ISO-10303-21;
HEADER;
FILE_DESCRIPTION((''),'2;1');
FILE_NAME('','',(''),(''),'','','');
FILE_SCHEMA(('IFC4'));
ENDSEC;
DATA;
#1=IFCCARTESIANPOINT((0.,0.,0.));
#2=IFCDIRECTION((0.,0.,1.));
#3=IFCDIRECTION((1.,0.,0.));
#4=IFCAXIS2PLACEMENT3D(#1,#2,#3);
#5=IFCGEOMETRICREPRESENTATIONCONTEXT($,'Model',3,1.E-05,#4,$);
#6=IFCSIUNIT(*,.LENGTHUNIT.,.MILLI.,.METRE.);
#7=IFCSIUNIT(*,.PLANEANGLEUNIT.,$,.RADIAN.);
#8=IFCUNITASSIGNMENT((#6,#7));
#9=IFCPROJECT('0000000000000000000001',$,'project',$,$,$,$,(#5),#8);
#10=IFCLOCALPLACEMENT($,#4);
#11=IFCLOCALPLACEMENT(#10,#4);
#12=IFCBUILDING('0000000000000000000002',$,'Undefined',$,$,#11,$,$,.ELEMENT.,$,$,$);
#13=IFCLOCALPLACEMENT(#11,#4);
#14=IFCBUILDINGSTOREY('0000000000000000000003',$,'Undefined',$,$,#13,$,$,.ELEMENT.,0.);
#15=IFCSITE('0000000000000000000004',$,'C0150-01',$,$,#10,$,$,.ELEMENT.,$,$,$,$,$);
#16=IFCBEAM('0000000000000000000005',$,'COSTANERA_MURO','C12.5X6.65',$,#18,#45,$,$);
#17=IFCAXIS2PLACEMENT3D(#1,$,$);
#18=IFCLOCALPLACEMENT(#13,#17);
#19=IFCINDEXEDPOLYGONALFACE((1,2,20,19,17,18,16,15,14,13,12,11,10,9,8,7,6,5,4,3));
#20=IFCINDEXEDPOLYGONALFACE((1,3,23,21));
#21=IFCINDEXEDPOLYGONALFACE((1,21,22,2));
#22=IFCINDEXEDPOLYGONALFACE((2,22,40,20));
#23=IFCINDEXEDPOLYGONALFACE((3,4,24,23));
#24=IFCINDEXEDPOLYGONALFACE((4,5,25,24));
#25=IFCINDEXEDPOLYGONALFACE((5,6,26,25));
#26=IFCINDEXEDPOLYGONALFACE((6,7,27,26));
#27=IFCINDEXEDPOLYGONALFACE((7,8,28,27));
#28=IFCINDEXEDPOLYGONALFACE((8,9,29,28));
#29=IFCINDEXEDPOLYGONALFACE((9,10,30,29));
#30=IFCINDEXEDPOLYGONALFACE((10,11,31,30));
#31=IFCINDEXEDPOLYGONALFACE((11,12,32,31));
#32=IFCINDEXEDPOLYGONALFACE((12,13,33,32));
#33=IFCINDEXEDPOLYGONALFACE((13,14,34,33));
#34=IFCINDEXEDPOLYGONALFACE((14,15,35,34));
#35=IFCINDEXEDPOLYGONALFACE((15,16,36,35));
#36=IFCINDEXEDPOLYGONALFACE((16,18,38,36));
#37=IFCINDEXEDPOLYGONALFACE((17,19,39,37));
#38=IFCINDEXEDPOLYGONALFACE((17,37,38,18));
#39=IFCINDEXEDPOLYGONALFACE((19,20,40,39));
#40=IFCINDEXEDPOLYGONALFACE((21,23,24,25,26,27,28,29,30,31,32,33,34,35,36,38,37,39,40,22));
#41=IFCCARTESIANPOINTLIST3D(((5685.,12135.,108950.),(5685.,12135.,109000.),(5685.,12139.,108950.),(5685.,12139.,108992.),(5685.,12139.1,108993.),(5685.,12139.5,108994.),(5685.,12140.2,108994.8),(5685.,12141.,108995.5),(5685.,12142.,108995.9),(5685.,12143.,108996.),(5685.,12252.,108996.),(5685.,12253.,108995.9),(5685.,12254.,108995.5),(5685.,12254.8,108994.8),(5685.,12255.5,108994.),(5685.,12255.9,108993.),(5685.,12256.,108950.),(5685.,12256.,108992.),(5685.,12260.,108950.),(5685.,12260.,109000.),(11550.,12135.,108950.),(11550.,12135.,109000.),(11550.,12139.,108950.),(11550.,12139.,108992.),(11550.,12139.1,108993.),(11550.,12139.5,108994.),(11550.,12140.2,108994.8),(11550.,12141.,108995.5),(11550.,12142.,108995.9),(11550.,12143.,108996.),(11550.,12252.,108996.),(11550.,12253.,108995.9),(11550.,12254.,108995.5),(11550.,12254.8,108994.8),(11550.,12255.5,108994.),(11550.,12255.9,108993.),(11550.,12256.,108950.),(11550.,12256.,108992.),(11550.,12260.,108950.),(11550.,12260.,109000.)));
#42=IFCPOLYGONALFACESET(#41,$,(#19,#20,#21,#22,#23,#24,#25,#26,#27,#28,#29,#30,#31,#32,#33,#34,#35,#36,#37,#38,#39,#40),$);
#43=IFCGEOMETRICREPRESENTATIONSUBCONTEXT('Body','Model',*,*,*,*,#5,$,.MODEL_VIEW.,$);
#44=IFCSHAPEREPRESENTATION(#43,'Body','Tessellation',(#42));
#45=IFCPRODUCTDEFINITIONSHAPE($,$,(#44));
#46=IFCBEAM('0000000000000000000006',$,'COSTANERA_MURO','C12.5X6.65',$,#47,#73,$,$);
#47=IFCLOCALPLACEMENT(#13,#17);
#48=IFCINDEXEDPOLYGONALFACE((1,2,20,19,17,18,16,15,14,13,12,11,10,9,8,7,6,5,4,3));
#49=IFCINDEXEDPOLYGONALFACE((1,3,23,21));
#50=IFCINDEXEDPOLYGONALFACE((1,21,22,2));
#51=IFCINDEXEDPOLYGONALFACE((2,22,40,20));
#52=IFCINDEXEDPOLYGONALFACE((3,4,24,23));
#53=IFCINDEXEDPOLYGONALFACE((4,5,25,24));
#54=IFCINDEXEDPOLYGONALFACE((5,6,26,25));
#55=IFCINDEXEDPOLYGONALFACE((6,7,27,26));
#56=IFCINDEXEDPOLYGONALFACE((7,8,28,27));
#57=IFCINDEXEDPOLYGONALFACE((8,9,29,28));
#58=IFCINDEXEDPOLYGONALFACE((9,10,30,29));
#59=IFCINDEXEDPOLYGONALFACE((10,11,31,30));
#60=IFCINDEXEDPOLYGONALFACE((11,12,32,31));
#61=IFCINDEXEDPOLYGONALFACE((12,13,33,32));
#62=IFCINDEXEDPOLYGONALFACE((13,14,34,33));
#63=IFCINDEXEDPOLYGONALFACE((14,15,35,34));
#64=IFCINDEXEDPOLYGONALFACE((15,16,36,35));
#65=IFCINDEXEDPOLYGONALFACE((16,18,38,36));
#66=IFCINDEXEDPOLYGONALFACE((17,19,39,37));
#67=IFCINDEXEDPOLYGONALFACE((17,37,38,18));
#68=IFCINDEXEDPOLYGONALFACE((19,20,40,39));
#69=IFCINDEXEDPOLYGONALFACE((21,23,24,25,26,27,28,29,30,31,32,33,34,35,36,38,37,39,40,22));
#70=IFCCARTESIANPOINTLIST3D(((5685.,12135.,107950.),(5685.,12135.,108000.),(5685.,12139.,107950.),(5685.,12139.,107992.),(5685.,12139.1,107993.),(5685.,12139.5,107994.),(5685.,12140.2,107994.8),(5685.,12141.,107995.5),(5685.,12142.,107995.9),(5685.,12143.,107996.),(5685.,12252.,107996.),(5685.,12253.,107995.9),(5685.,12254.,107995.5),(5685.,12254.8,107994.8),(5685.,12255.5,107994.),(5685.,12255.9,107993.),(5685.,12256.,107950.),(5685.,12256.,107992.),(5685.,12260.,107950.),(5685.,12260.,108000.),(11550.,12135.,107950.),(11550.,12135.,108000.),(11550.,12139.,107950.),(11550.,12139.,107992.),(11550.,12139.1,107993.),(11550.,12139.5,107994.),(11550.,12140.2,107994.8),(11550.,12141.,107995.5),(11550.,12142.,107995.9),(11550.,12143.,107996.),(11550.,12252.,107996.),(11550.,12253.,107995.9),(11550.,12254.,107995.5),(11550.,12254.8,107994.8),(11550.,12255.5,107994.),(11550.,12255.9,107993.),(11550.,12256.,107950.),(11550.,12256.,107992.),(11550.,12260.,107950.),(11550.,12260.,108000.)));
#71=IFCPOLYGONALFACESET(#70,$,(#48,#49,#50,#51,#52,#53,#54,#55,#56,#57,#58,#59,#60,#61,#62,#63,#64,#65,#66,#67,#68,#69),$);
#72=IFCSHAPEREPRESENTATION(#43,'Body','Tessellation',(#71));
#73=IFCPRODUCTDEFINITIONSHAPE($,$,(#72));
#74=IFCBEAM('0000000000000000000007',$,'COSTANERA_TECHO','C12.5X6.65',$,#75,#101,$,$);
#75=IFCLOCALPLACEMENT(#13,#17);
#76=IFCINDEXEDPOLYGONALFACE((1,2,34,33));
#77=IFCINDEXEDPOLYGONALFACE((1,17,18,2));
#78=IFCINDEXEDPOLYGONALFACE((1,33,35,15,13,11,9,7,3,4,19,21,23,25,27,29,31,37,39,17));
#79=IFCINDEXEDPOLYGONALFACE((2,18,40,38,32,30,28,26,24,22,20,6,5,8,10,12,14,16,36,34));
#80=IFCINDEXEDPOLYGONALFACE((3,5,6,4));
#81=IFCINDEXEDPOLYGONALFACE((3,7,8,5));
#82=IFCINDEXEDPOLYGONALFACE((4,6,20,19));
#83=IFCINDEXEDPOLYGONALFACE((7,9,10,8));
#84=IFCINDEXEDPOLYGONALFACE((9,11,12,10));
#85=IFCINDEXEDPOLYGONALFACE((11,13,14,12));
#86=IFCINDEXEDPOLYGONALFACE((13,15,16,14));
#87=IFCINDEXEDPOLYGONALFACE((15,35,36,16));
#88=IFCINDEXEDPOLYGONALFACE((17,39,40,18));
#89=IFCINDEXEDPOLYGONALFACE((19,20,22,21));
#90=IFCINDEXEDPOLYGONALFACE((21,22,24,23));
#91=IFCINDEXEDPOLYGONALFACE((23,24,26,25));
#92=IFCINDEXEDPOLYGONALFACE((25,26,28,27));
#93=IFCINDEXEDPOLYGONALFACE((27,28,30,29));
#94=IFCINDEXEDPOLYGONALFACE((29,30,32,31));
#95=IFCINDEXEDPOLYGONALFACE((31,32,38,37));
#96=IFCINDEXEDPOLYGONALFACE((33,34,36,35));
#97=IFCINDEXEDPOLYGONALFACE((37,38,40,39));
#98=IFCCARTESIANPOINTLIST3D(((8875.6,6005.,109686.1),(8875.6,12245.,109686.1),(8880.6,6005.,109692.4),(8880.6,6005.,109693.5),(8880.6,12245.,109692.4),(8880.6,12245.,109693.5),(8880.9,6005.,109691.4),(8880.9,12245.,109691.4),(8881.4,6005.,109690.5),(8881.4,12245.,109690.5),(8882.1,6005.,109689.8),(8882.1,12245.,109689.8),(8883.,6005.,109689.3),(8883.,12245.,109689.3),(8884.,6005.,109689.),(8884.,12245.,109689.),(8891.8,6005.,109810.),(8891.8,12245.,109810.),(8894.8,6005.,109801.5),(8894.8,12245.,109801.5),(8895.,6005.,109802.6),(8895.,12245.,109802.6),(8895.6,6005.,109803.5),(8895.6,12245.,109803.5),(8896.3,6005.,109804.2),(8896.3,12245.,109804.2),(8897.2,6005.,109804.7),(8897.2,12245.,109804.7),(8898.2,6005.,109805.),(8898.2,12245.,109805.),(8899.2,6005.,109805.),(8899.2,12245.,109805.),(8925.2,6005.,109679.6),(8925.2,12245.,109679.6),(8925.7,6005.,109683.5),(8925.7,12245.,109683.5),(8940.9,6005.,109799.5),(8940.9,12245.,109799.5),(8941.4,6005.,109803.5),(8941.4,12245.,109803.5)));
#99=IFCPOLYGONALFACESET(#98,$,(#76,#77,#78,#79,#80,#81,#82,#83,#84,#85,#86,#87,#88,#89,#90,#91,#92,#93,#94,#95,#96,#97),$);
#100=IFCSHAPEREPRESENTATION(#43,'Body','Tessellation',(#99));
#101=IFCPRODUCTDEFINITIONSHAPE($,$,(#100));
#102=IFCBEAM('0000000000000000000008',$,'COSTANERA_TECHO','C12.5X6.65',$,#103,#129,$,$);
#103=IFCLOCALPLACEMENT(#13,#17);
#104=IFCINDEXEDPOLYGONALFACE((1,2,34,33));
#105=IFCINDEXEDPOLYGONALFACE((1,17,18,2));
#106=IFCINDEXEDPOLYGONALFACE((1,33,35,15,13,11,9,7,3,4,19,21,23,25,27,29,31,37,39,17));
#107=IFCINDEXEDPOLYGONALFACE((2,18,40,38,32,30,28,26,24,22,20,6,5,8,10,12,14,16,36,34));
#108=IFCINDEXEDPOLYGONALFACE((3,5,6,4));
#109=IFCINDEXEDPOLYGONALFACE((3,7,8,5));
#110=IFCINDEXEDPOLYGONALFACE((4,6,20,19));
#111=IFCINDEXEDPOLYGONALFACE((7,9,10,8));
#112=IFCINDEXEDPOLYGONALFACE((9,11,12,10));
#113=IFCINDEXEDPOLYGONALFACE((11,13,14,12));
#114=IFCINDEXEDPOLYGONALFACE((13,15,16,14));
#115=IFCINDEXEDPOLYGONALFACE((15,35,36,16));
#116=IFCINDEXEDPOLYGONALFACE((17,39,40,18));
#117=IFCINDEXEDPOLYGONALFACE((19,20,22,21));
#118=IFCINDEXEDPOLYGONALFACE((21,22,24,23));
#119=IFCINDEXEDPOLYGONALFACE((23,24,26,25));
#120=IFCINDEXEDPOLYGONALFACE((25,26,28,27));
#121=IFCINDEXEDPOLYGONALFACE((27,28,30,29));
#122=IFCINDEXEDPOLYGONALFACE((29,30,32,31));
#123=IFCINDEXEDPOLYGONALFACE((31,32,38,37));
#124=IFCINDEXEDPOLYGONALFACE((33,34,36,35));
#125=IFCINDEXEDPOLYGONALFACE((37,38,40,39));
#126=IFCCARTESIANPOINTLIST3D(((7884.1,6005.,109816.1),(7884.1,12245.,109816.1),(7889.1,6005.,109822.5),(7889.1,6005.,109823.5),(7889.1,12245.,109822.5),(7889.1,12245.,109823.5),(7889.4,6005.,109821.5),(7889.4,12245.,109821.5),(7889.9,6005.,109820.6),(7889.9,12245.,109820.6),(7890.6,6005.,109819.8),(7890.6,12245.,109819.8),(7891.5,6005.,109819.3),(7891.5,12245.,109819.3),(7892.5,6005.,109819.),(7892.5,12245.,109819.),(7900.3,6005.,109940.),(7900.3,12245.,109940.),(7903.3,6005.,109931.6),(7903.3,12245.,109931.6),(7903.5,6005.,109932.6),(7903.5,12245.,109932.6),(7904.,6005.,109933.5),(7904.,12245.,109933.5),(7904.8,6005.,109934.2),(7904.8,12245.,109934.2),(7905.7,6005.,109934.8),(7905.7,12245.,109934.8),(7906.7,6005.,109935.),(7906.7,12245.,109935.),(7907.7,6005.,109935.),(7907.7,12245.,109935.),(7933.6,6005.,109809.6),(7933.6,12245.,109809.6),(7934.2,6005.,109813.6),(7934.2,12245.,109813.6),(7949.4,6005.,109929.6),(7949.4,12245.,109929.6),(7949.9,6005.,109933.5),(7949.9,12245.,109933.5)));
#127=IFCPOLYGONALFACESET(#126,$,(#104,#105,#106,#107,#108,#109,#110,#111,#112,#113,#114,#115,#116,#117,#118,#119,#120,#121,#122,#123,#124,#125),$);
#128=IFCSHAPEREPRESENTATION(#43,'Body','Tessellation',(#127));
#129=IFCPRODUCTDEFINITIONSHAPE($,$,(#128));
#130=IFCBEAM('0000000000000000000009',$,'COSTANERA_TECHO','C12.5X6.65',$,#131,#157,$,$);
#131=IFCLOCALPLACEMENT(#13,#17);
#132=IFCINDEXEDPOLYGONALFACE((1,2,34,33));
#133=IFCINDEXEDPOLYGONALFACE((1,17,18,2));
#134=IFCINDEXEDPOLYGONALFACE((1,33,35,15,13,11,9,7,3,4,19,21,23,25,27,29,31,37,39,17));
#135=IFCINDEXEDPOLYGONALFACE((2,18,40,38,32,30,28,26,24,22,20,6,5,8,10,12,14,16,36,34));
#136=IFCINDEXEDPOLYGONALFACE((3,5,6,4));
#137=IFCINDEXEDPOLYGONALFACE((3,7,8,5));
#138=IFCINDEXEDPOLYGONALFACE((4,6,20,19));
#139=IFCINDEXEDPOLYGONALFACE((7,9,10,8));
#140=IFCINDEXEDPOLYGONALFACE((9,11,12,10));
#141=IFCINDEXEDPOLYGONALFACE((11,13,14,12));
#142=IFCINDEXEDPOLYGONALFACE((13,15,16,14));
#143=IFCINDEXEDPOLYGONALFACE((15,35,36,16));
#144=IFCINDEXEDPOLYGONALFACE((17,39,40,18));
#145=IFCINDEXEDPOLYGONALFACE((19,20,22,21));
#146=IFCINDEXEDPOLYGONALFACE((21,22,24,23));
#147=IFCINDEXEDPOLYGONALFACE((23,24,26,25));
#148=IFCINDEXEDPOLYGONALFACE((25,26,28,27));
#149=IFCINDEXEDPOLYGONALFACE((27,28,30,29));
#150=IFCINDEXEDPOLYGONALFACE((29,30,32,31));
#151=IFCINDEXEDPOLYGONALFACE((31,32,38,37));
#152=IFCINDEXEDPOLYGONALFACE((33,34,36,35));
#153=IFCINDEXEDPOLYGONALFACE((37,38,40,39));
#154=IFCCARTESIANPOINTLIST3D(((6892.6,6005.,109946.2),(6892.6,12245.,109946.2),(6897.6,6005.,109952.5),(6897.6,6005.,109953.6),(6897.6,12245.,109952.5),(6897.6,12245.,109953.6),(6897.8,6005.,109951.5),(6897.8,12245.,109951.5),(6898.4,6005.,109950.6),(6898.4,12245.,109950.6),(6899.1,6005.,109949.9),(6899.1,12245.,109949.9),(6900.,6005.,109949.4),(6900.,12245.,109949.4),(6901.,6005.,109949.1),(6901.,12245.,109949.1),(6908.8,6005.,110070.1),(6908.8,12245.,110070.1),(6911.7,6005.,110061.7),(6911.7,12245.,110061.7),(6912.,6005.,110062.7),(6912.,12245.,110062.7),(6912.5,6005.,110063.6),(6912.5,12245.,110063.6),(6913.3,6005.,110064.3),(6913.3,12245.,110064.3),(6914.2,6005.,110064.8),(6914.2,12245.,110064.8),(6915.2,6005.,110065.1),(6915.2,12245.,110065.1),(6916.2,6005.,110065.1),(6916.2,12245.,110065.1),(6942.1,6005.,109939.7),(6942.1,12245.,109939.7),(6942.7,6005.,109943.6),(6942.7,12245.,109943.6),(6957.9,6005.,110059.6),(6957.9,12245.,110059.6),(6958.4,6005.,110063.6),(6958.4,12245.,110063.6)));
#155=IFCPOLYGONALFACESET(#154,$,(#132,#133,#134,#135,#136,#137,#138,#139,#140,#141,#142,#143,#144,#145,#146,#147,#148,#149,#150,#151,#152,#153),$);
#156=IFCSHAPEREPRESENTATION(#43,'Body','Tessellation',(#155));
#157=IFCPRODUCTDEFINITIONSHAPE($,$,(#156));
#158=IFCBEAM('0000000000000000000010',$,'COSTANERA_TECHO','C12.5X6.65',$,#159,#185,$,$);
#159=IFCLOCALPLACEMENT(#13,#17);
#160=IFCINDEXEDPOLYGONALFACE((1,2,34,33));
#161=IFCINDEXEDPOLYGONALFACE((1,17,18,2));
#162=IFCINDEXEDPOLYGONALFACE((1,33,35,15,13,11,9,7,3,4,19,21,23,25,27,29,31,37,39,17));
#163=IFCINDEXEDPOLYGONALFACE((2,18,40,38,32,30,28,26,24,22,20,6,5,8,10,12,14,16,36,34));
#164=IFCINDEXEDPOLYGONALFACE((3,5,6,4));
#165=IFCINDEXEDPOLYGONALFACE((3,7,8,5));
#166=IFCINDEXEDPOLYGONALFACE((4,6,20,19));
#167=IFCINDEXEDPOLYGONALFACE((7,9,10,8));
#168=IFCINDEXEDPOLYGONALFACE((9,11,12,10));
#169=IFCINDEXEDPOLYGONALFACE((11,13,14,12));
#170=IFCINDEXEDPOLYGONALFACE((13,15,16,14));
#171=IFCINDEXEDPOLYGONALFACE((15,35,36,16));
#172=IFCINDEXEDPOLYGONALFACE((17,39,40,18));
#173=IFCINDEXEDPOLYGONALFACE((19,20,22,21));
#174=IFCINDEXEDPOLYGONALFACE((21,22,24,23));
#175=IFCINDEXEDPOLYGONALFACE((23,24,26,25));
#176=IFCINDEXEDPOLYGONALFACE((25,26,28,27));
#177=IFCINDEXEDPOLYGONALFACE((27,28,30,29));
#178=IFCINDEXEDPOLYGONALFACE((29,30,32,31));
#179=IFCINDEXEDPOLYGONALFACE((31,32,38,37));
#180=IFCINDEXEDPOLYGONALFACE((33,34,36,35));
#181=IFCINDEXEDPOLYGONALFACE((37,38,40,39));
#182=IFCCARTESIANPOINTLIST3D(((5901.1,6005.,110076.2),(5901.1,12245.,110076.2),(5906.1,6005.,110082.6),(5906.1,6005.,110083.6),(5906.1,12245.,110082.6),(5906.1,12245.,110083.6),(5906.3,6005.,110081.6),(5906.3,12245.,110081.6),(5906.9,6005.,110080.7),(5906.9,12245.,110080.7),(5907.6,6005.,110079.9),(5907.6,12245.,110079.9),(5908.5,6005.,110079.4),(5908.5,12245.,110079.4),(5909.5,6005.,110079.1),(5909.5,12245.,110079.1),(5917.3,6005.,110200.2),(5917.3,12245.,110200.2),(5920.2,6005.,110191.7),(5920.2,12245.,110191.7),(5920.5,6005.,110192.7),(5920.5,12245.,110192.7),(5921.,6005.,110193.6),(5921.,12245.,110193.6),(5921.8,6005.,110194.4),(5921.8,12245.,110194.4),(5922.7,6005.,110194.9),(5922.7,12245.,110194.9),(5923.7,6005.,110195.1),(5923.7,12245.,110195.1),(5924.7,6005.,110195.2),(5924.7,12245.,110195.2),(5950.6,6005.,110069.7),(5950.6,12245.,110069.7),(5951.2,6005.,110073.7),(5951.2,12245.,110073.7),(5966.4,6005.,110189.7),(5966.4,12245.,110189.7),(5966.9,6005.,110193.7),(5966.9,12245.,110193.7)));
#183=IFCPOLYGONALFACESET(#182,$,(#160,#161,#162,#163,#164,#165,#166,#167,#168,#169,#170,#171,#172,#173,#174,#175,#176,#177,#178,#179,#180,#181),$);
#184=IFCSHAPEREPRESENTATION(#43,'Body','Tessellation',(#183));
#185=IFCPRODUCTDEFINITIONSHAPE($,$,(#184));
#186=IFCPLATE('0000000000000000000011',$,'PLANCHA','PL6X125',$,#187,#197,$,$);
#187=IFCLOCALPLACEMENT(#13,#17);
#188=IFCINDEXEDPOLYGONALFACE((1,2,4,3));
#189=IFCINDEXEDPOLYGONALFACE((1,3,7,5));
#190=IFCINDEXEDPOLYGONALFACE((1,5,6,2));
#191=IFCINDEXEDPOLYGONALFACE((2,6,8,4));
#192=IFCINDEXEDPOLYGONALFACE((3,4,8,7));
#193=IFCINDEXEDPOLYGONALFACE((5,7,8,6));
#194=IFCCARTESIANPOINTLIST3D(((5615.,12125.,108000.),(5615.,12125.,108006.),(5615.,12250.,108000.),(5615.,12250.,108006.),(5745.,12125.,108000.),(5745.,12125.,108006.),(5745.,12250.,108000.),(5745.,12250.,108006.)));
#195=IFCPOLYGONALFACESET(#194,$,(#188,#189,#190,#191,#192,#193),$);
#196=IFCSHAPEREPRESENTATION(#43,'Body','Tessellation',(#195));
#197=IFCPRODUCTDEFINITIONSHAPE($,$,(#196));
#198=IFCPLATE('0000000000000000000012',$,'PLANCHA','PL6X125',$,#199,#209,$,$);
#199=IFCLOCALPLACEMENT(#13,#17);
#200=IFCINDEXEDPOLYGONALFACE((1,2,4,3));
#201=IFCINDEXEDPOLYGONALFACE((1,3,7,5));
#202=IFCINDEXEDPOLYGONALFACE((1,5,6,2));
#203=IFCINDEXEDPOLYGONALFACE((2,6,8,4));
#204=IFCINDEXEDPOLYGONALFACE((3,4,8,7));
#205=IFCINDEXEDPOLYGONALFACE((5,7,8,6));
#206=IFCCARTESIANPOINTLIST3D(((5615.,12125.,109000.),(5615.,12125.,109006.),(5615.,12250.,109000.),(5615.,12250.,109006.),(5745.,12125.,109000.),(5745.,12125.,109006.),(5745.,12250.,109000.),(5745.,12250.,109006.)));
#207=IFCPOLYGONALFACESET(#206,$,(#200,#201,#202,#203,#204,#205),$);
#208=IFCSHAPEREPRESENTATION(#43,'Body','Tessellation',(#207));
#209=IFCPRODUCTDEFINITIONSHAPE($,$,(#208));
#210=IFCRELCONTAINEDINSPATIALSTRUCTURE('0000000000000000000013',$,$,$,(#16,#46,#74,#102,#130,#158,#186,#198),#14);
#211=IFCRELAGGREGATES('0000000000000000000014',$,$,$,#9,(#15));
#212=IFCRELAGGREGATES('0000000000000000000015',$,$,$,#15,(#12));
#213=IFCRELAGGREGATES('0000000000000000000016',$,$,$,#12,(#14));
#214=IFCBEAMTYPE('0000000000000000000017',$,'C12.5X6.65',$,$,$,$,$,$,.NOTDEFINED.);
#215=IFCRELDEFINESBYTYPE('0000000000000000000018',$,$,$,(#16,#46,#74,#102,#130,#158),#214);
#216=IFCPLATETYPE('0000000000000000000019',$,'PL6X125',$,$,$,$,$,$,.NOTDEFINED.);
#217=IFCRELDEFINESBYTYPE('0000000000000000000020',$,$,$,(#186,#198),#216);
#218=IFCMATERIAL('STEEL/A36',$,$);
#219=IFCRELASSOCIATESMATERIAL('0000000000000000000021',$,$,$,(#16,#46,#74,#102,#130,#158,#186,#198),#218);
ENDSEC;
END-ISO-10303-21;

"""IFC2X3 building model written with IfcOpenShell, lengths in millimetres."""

from ifc_helpers import new_model, si_unit, frame, origin_with_axes, origin_2d_with_axis, place, context, subcontext, project, spatial, polyline, u_section, outline, extrude, material, type_object, element, save


model = new_model("IFC2X3")

# Units and contexts
model_context = context("Model", 3, precision=1e-05, world=origin_with_axes())
body_context = subcontext(model_context, "Body", "Model", "MODEL_VIEW")
ifc_project = project(units=[si_unit("LENGTHUNIT", "METRE", prefix="MILLI"), si_unit("PLANEANGLEUNIT", "RADIAN")], contexts=[model_context])

# Site, building, storey
site_placement = place(None, origin_with_axes())
site = spatial("IfcSite", under=ifc_project, at=site_placement, Name="C0150-01", CompositionType="ELEMENT")
building_placement = place(site_placement, origin_with_axes())
building = spatial("IfcBuilding", under=site, at=building_placement, Name="Undefined", CompositionType="ELEMENT")
storey_placement = place(building_placement, origin_with_axes())
storey = spatial("IfcBuildingStorey", under=building, at=storey_placement, Name="Undefined", CompositionType="ELEMENT", Elevation=0.0)

# Beams
ifc_material_1 = material(Name="STEEL/A36")
beam_type = type_object("IfcBeamType", Name="C12.5X6.65", PredefinedType="NOTDEFINED")
for number, where, z_axis, x_axis, name in (
    (1, (5685.0, 12197.5, 108975.0), (0.0, -1.0, 0.0), (1.0, 0.0, 0.0), "COSTANERA_MURO"),
    (2, (5685.0, 12197.5, 107975.0), (0.0, -1.0, 0.0), (1.0, 0.0, 0.0), "COSTANERA_MURO"),
):
    element("IfcBeam", number, at=place(storey_placement, frame(where, z_axis=z_axis, x_axis=x_axis)), inside=storey, type_object=beam_type, material=ifc_material_1, Name=name, Description="C12.5X6.65", context=body_context, shape_type="SweptSolid", body=[
        extrude(u_section(Depth=125.0, FlangeWidth=50.0, WebThickness=4.0, FlangeThickness=4.0, FilletRadius=4.0, at=origin_2d_with_axis()), frame((5865.0, 0.0, 0.0), z_axis=(-1.0, 0.0, 0.0), x_axis=(0.0, -1.0, 0.0)), (0.0, 0.0, 1.0), 5865.0),
    ])
for number, where, z_axis, x_axis, name in (
    (3, (8908.5, 12245.0, 109744.8), (-0.130054, 0.0, -0.991507), (0.0, -1.0, 0.0), "COSTANERA_TECHO"),
    (4, (7917.0, 12245.0, 109874.8), (-0.130054, 0.0, -0.991507), (0.0, -1.0, 0.0), "COSTANERA_TECHO"),
    (5, (6925.5, 12245.0, 110004.9), (-0.130054, 0.0, -0.991507), (0.0, -1.0, 0.0), "COSTANERA_TECHO"),
    (6, (5934.0, 12245.0, 110134.9), (-0.130054, 0.0, -0.991507), (0.0, -1.0, 0.0), "COSTANERA_TECHO"),
):
    element("IfcBeam", number, at=place(storey_placement, frame(where, z_axis=z_axis, x_axis=x_axis)), inside=storey, type_object=beam_type, material=ifc_material_1, Name=name, Description="C12.5X6.65", context=body_context, shape_type="SweptSolid", body=[
        extrude(u_section(Depth=125.0, FlangeWidth=50.0, WebThickness=4.0, FlangeThickness=4.0, FilletRadius=4.0, at=origin_2d_with_axis()), frame((6240.0, 0.0, 0.0), z_axis=(-1.0, 0.0, 0.0), x_axis=(0.0, -1.0, 0.0)), (0.0, 0.0, 1.0), 6240.0),
    ])

# Plates
plate_type_1 = type_object("IfcPlateType", Name="PL6X125", PredefinedType="NOTDEFINED")
for number, where, z_axis, x_axis, name in (
    (7, (5745.0, 12125.0, 108003.0), (0.0, 0.000004, -1.0), (-1.0, 0.0, 0.0), "PLANCHA"),
    (8, (5745.0, 12125.0, 109003.0), (0.0, 0.000004, -1.0), (-1.0, 0.0, 0.0), "PLANCHA"),
):
    element("IfcPlate", number, at=place(storey_placement, frame(where, z_axis=z_axis, x_axis=x_axis)), inside=storey, type_object=plate_type_1, material=ifc_material_1, Name=name, Description="PL6X125", context=body_context, shape_type="SweptSolid", body=[
        extrude(outline(polyline([(0.0, 0.0), (130.0, 0.0), (130.0, 125.0), (0.0, 125.0), (0.0, 0.0)])), frame((0.0, 0.0, -3.0), z_axis=(0.0, 0.0, 1.0), x_axis=(1.0, 0.0, 0.0)), (0.0, 0.0, 1.0), 6.0),
    ])

save(model, "model.ifc")
